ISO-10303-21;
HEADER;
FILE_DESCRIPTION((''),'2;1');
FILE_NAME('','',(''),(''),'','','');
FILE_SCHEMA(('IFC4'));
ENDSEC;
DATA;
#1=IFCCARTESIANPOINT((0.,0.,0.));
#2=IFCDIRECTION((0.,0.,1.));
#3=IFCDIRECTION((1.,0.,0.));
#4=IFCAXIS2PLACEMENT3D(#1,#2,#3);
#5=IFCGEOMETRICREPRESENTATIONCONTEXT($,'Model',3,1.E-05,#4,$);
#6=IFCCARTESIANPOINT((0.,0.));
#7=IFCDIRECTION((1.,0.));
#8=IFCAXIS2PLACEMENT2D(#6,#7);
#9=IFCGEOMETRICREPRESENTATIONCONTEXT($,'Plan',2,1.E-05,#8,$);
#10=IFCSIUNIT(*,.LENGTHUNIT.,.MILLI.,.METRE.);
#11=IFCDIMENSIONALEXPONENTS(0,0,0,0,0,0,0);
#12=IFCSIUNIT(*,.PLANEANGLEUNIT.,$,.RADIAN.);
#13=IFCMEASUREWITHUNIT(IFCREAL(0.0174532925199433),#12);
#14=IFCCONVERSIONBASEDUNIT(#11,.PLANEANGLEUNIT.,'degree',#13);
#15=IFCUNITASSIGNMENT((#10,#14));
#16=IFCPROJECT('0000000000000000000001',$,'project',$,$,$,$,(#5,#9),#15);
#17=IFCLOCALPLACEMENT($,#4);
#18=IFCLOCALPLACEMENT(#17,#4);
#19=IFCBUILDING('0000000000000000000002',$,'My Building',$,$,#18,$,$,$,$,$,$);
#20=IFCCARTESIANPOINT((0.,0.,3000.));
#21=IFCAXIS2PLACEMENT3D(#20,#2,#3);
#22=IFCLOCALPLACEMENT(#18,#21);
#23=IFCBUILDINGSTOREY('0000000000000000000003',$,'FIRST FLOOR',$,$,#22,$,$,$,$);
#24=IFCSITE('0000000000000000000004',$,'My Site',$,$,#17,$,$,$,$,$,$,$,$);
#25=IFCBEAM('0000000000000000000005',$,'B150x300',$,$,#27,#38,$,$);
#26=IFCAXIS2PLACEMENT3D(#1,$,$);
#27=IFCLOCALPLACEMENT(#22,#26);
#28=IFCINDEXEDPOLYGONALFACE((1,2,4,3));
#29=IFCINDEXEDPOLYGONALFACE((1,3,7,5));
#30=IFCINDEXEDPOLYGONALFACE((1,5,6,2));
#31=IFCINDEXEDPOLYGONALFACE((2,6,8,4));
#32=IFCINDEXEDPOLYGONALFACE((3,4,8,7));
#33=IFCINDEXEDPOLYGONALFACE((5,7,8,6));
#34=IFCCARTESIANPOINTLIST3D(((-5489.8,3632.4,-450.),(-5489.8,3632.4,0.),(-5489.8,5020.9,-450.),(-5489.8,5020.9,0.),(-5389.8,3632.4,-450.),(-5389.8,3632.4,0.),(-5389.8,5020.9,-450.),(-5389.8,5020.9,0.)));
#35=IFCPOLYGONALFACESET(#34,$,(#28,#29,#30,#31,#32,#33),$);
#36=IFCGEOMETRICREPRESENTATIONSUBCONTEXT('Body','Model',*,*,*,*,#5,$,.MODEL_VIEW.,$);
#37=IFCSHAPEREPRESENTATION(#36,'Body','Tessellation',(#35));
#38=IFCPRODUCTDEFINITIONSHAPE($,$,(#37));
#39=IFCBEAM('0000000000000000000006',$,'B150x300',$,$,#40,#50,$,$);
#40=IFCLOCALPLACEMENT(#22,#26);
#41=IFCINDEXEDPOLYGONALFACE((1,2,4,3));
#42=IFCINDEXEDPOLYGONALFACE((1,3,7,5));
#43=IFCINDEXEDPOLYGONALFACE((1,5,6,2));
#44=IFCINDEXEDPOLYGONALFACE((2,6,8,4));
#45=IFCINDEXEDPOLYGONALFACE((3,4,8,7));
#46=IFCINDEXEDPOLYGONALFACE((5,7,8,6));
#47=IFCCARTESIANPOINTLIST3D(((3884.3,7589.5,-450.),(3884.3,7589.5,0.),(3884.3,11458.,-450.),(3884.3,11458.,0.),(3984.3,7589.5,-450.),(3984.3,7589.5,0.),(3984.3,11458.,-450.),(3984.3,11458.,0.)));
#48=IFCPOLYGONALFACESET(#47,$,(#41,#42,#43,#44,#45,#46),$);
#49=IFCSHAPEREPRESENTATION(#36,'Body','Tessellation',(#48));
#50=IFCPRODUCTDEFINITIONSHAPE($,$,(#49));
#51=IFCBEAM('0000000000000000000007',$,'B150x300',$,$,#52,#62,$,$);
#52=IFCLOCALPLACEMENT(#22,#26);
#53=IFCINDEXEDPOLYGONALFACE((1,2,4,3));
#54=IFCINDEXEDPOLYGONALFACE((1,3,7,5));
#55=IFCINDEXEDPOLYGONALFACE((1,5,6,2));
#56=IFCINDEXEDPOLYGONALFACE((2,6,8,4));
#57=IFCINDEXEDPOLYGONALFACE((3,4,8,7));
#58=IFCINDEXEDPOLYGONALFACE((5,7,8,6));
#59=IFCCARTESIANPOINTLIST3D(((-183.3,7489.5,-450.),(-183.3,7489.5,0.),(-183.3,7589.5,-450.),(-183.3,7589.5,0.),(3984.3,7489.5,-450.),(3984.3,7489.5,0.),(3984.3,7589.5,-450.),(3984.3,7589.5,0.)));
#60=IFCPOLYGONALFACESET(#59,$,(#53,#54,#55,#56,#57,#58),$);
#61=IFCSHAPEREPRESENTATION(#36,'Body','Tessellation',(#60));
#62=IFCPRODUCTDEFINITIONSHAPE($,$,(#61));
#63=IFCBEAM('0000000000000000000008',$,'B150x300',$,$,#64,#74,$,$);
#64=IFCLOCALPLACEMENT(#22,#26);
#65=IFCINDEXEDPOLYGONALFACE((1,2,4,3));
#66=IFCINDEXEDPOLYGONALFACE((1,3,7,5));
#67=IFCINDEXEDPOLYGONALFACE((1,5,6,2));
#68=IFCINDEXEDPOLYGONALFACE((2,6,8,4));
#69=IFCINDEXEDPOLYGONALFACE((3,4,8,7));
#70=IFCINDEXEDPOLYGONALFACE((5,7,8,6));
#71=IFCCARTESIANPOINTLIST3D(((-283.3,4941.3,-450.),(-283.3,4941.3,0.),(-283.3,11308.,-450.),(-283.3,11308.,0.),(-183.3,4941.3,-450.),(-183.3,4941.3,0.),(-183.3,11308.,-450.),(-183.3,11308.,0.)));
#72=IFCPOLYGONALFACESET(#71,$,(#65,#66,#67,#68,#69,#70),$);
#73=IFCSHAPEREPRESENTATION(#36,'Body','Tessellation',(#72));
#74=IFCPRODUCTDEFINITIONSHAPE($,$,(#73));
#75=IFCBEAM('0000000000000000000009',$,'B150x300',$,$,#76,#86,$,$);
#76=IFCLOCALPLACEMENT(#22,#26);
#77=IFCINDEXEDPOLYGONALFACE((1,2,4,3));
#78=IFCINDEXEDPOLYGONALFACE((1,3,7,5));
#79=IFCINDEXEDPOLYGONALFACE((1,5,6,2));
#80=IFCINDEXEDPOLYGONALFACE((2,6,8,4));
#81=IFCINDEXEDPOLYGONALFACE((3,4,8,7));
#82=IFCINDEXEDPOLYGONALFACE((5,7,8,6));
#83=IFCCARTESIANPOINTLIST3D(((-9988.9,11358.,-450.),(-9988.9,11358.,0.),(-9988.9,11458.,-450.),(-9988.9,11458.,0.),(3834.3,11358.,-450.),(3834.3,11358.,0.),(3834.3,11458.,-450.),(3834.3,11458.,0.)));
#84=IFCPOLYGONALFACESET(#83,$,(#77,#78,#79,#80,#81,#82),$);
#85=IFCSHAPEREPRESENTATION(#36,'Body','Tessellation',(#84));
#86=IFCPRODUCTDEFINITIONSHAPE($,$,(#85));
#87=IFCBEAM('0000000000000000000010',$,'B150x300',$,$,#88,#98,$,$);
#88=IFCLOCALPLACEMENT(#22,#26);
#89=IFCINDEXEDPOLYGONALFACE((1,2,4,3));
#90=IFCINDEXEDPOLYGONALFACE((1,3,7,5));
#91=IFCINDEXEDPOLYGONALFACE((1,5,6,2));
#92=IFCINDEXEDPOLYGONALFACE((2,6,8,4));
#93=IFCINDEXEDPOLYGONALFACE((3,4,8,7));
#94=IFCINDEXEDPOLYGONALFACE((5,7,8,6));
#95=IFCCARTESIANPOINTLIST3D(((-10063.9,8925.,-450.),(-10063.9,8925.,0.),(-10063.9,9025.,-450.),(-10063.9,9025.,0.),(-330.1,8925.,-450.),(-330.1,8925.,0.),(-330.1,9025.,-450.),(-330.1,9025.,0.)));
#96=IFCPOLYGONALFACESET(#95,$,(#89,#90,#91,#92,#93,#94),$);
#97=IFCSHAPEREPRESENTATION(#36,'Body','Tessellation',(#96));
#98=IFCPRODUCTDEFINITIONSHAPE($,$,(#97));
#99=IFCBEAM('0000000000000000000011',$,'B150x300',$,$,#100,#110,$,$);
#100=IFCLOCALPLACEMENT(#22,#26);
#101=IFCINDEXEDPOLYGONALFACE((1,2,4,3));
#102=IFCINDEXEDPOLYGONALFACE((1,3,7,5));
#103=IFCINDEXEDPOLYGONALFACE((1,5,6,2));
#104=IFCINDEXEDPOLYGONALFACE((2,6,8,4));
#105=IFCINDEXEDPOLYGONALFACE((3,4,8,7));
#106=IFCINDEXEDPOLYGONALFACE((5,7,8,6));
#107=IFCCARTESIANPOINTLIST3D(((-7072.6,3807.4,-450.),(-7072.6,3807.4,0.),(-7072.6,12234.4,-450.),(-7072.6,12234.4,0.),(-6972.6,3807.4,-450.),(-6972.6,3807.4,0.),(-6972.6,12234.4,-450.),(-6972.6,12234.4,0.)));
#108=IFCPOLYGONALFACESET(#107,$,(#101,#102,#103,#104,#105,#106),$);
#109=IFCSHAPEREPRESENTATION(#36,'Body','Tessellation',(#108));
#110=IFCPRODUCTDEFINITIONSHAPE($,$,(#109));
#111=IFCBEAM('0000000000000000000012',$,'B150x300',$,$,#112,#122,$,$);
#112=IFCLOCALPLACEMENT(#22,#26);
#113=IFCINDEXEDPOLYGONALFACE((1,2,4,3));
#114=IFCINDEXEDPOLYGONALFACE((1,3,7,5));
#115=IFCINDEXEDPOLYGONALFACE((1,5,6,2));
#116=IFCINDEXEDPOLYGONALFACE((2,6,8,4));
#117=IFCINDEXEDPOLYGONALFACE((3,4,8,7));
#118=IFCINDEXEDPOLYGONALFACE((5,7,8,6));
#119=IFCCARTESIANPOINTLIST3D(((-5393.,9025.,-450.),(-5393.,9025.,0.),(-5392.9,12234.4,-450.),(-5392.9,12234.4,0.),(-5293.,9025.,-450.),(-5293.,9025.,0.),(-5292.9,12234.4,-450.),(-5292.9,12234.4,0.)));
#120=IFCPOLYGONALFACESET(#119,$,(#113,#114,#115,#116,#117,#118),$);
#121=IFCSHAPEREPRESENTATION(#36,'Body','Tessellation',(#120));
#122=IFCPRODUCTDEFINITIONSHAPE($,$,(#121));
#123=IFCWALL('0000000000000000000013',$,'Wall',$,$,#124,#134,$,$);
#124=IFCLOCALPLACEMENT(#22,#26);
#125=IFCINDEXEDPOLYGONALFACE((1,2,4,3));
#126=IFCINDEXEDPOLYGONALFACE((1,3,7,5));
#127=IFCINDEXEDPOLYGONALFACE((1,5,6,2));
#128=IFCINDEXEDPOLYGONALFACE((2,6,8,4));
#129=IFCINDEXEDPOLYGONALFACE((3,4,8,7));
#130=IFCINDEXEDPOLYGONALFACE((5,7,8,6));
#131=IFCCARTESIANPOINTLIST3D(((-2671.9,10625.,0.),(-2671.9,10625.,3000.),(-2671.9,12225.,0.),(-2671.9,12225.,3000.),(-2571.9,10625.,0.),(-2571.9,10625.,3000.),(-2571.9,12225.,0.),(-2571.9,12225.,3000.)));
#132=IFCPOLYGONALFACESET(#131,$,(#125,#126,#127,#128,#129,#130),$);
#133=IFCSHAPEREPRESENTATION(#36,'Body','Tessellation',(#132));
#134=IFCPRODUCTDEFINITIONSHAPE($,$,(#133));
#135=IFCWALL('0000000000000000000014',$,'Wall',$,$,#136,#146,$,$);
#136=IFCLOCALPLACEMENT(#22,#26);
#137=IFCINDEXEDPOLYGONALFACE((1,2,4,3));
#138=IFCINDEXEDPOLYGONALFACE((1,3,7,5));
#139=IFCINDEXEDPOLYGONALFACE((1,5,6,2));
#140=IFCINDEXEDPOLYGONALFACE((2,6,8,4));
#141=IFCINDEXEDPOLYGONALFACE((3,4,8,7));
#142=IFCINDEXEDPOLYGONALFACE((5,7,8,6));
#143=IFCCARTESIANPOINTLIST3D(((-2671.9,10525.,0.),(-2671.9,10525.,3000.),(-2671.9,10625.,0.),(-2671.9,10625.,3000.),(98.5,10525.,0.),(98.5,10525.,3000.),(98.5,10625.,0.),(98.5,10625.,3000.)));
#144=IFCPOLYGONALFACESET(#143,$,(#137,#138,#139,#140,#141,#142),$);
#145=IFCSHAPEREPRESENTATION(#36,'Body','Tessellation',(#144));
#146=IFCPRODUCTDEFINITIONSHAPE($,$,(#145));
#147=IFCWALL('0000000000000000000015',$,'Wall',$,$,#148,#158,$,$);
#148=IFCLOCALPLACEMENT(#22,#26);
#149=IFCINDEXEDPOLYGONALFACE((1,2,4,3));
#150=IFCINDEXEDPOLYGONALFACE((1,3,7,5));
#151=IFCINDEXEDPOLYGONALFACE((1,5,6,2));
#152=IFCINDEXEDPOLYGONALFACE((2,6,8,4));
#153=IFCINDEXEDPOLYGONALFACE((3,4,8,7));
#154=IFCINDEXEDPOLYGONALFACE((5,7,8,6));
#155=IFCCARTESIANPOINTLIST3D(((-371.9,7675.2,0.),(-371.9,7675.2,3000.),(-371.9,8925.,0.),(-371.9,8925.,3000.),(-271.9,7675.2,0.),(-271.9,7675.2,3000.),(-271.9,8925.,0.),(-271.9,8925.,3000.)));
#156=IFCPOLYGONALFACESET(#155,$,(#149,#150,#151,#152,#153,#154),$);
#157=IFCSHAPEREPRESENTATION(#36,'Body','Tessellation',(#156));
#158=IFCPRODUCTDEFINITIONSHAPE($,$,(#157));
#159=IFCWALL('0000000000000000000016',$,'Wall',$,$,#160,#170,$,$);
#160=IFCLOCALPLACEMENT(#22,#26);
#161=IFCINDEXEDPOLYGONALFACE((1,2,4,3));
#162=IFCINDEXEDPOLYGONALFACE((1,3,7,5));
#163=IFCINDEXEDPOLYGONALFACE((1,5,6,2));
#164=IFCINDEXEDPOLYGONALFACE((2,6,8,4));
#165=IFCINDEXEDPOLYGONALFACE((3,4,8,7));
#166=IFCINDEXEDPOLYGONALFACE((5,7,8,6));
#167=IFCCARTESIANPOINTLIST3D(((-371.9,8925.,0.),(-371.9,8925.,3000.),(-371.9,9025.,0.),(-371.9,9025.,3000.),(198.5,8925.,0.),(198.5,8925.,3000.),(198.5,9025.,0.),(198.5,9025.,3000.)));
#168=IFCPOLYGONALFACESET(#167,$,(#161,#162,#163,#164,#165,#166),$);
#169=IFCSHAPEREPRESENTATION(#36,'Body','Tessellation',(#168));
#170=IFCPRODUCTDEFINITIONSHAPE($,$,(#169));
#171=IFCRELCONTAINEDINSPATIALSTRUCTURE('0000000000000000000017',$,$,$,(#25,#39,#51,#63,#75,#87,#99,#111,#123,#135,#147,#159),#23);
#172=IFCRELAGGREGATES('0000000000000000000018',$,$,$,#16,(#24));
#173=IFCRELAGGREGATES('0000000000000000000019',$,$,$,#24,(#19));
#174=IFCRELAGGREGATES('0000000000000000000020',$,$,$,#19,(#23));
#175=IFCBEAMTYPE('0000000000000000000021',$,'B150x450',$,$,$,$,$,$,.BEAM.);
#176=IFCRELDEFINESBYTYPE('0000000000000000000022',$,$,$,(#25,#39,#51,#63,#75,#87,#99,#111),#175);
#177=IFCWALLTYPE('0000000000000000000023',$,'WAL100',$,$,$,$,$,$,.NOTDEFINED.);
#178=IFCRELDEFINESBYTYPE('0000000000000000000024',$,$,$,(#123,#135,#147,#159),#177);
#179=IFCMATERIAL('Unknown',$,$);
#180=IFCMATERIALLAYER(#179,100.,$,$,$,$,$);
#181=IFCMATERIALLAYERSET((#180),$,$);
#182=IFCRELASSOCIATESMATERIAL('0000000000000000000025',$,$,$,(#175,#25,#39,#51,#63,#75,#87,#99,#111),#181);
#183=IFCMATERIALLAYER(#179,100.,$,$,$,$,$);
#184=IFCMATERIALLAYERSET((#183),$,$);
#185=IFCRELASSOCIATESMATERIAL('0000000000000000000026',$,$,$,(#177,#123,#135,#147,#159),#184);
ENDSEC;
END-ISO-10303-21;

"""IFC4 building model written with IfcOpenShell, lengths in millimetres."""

from ifc_helpers import new_model, entity, si_unit, converted_unit, frame, origin_with_axes, origin_2d_with_axis, place, context, subcontext, project, spatial, indexed_curve, outline, extrude, material, layer, layer_set, layer_usage, type_object, element, save


model = new_model("IFC4")

# Units and contexts
model_context = context("Model", 3, precision=1e-05, world=origin_with_axes())
plan_context = context("Plan", 2, precision=1e-05, world=origin_2d_with_axis())
body_context_1 = subcontext(model_context, "Body", "Model", "MODEL_VIEW")
ifc_project = project(units=[si_unit("LENGTHUNIT", "METRE", prefix="MILLI"), converted_unit("PLANEANGLEUNIT", "degree", entity("IfcReal", 0.0174532925199433), si_unit("PLANEANGLEUNIT", "RADIAN"), dimensions=[0, 0, 0, 0, 0, 0, 0])], contexts=[model_context, plan_context])

# Site, building, storey
site_placement = place(None, origin_with_axes())
site = spatial("IfcSite", under=ifc_project, at=site_placement, Name="My Site")
building_placement = place(site_placement, origin_with_axes())
building = spatial("IfcBuilding", under=site, at=building_placement, Name="My Building")
storey_placement = place(building_placement, frame((0.0, 0.0, 3000.0), z_axis=(0.0, 0.0, 1.0), x_axis=(1.0, 0.0, 0.0)))
storey = spatial("IfcBuildingStorey", under=building, at=storey_placement, Name="FIRST FLOOR")

# Beams
ifc_material = material(Name="Unknown")
ifc_layer_1 = layer(ifc_material, 100.0)
ifc_layer_set_1 = layer_set([ifc_layer_1])
ifc_layer_usage_1 = layer_usage(ifc_layer_set_1, "AXIS2", "POSITIVE", 0.0)
beam_type = type_object("IfcBeamType", Name="B150x450", PredefinedType="BEAM", material=ifc_layer_set_1)
beam_1_placement = place(storey_placement, frame((-5389.8, 3632.4, -450.0), z_axis=(0.0, 0.0, 1.0), x_axis=(0.0, 1.0, 0.0)))
element("IfcBeam", 1, at=beam_1_placement, inside=storey, type_object=beam_type, material=ifc_layer_usage_1, Name="B150x300", context=body_context_1, shape_type="SweptSolid", body=[
    extrude(outline(indexed_curve([(0.0, 0.0), (0.0, 100.0), (1388.5, 100.0), (1388.5, 0.0), (0.0, 0.0)], self_intersect=False)), origin_with_axes(), (0.0, 0.0, 1.0), 450.0),
])
ifc_layer_usage_2 = layer_usage(ifc_layer_set_1, "AXIS2", "POSITIVE", 0.0)
beam_2_placement = place(storey_placement, frame((3984.3, 7589.5, -450.0), z_axis=(0.0, 0.0, 1.0), x_axis=(0.0, 1.0, 0.0)))
element("IfcBeam", 2, at=beam_2_placement, inside=storey, type_object=beam_type, material=ifc_layer_usage_2, Name="B150x300", context=body_context_1, shape_type="SweptSolid", body=[
    extrude(outline(indexed_curve([(0.0, 0.0), (0.0, 100.0), (3868.5, 100.0), (3868.5, 0.0), (0.0, 0.0)], self_intersect=False)), origin_with_axes(), (0.0, 0.0, 1.0), 450.0),
])
ifc_layer_usage_3 = layer_usage(ifc_layer_set_1, "AXIS2", "POSITIVE", 0.0)
beam_3_placement = place(storey_placement, frame((-183.3, 7489.5, -450.0), z_axis=(0.0, 0.0, 1.0), x_axis=(1.0, 0.0, 0.0)))
element("IfcBeam", 3, at=beam_3_placement, inside=storey, type_object=beam_type, material=ifc_layer_usage_3, Name="B150x300", context=body_context_1, shape_type="SweptSolid", body=[
    extrude(outline(indexed_curve([(0.0, 0.0), (0.0, 100.0), (4167.6, 100.0), (4167.6, 0.0), (0.0, 0.0)], self_intersect=False)), origin_with_axes(), (0.0, 0.0, 1.0), 450.0),
])
ifc_layer_usage_4 = layer_usage(ifc_layer_set_1, "AXIS2", "POSITIVE", 0.0)
beam_4_placement = place(storey_placement, frame((-183.3, 4941.3, -450.0), z_axis=(0.0, 0.0, 1.0), x_axis=(0.0, 1.0, 0.0)))
element("IfcBeam", 4, at=beam_4_placement, inside=storey, type_object=beam_type, material=ifc_layer_usage_4, Name="B150x300", context=body_context_1, shape_type="SweptSolid", body=[
    extrude(outline(indexed_curve([(0.0, 0.0), (0.0, 100.0), (6366.6, 100.0), (6366.6, 0.0), (0.0, 0.0)], self_intersect=False)), origin_with_axes(), (0.0, 0.0, 1.0), 450.0),
])
ifc_layer_usage_5 = layer_usage(ifc_layer_set_1, "AXIS2", "POSITIVE", 0.0)
beam_5_placement = place(storey_placement, frame((3834.3, 11458.0, -450.0), z_axis=(0.0, 0.0, 1.0), x_axis=(-1.0, 0.0, 0.0)))
element("IfcBeam", 5, at=beam_5_placement, inside=storey, type_object=beam_type, material=ifc_layer_usage_5, Name="B150x300", context=body_context_1, shape_type="SweptSolid", body=[
    extrude(outline(indexed_curve([(0.0, 0.0), (0.0, 100.0), (13823.2, 100.0), (13823.2, 0.0), (0.0, 0.0)], self_intersect=False)), origin_with_axes(), (0.0, 0.0, 1.0), 450.0),
])
ifc_layer_usage_6 = layer_usage(ifc_layer_set_1, "AXIS2", "POSITIVE", 0.0)
beam_6_placement = place(storey_placement, frame((-330.1, 9025.0, -450.0), z_axis=(0.0, 0.0, 1.0), x_axis=(-1.0, 0.0, 0.0)))
element("IfcBeam", 6, at=beam_6_placement, inside=storey, type_object=beam_type, material=ifc_layer_usage_6, Name="B150x300", context=body_context_1, shape_type="SweptSolid", body=[
    extrude(outline(indexed_curve([(0.0, 0.0), (0.0, 100.0), (9733.8, 100.0), (9733.8, 0.0), (0.0, 0.0)], self_intersect=False)), origin_with_axes(), (0.0, 0.0, 1.0), 450.0),
])
ifc_layer_usage_7 = layer_usage(ifc_layer_set_1, "AXIS2", "POSITIVE", 0.0)
beam_7_placement = place(storey_placement, frame((-7072.6, 12234.4, -450.0), z_axis=(0.0, 0.0, 1.0), x_axis=(0.0, -1.0, 0.0)))
element("IfcBeam", 7, at=beam_7_placement, inside=storey, type_object=beam_type, material=ifc_layer_usage_7, Name="B150x300", context=body_context_1, shape_type="SweptSolid", body=[
    extrude(outline(indexed_curve([(0.0, 0.0), (0.0, 100.0), (8427.0, 100.0), (8427.0, 0.0), (0.0, 0.0)], self_intersect=False)), origin_with_axes(), (0.0, 0.0, 1.0), 450.0),
])
ifc_layer_usage_8 = layer_usage(ifc_layer_set_1, "AXIS2", "POSITIVE", 0.0)
beam_8_placement = place(storey_placement, frame((-5392.9, 12234.4, -450.0), z_axis=(0.0, 0.0, 1.0), x_axis=(0.0, -1.0, 0.0)))
element("IfcBeam", 8, at=beam_8_placement, inside=storey, type_object=beam_type, material=ifc_layer_usage_8, Name="B150x300", context=body_context_1, shape_type="SweptSolid", body=[
    extrude(outline(indexed_curve([(0.0, 0.0), (0.0, 100.0), (3209.4, 100.0), (3209.4, 0.0), (0.0, 0.0)], self_intersect=False)), origin_with_axes(), (0.0, 0.0, 1.0), 450.0),
])

# Walls
ifc_layer_2 = layer(ifc_material, 100.0)
ifc_layer_set_2 = layer_set([ifc_layer_2])
ifc_layer_usage_9 = layer_usage(ifc_layer_set_2, "AXIS2", "POSITIVE", 0.0)
wall_type_1 = type_object("IfcWallType", Name="WAL100", PredefinedType="NOTDEFINED", material=ifc_layer_set_2)
wall_1_placement = place(storey_placement, frame((-2571.9, 10625.0, 0.0), z_axis=(0.0, 0.0, 1.0), x_axis=(0.0, 1.0, 0.0)))
element("IfcWall", 9, at=wall_1_placement, inside=storey, type_object=wall_type_1, material=ifc_layer_usage_9, Name="Wall", context=body_context_1, shape_type="SweptSolid", body=[
    extrude(outline(indexed_curve([(0.0, 0.0), (0.0, 100.0), (1600.0, 100.0), (1600.0, 0.0), (0.0, 0.0)], self_intersect=False)), origin_with_axes(), (0.0, 0.0, 1.0), 3000.0),
])
ifc_layer_usage_10 = layer_usage(ifc_layer_set_2, "AXIS2", "POSITIVE", 0.0)
wall_2_placement = place(storey_placement, frame((98.5, 10625.0, 0.0), z_axis=(0.0, 0.0, 1.0), x_axis=(-1.0, 0.0, 0.0)))
element("IfcWall", 10, at=wall_2_placement, inside=storey, type_object=wall_type_1, material=ifc_layer_usage_10, Name="Wall", context=body_context_1, shape_type="SweptSolid", body=[
    extrude(outline(indexed_curve([(0.0, 0.0), (0.0, 100.0), (2770.4, 100.0), (2770.4, 0.0), (0.0, 0.0)], self_intersect=False)), origin_with_axes(), (0.0, 0.0, 1.0), 3000.0),
])
ifc_layer_usage_11 = layer_usage(ifc_layer_set_2, "AXIS2", "POSITIVE", 0.0)
wall_3_placement = place(storey_placement, frame((-271.9, 7675.2, 0.0), z_axis=(0.0, 0.0, 1.0), x_axis=(0.0, 1.0, 0.0)))
element("IfcWall", 11, at=wall_3_placement, inside=storey, type_object=wall_type_1, material=ifc_layer_usage_11, Name="Wall", context=body_context_1, shape_type="SweptSolid", body=[
    extrude(outline(indexed_curve([(0.0, 0.0), (0.0, 100.0), (1249.8, 100.0), (1249.8, 0.0), (0.0, 0.0)], self_intersect=False)), origin_with_axes(), (0.0, 0.0, 1.0), 3000.0),
])
ifc_layer_usage_12 = layer_usage(ifc_layer_set_2, "AXIS2", "POSITIVE", 0.0)
wall_4_placement = place(storey_placement, frame((-371.9, 8925.0, 0.0), z_axis=(0.0, 0.0, 1.0), x_axis=(1.0, 0.0, 0.0)))
element("IfcWall", 12, at=wall_4_placement, inside=storey, type_object=wall_type_1, material=ifc_layer_usage_12, Name="Wall", context=body_context_1, shape_type="SweptSolid", body=[
    extrude(outline(indexed_curve([(0.0, 0.0), (0.0, 100.0), (570.4, 100.0), (570.4, 0.0), (0.0, 0.0)], self_intersect=False)), origin_with_axes(), (0.0, 0.0, 1.0), 3000.0),
])

save(model, "model.ifc")
